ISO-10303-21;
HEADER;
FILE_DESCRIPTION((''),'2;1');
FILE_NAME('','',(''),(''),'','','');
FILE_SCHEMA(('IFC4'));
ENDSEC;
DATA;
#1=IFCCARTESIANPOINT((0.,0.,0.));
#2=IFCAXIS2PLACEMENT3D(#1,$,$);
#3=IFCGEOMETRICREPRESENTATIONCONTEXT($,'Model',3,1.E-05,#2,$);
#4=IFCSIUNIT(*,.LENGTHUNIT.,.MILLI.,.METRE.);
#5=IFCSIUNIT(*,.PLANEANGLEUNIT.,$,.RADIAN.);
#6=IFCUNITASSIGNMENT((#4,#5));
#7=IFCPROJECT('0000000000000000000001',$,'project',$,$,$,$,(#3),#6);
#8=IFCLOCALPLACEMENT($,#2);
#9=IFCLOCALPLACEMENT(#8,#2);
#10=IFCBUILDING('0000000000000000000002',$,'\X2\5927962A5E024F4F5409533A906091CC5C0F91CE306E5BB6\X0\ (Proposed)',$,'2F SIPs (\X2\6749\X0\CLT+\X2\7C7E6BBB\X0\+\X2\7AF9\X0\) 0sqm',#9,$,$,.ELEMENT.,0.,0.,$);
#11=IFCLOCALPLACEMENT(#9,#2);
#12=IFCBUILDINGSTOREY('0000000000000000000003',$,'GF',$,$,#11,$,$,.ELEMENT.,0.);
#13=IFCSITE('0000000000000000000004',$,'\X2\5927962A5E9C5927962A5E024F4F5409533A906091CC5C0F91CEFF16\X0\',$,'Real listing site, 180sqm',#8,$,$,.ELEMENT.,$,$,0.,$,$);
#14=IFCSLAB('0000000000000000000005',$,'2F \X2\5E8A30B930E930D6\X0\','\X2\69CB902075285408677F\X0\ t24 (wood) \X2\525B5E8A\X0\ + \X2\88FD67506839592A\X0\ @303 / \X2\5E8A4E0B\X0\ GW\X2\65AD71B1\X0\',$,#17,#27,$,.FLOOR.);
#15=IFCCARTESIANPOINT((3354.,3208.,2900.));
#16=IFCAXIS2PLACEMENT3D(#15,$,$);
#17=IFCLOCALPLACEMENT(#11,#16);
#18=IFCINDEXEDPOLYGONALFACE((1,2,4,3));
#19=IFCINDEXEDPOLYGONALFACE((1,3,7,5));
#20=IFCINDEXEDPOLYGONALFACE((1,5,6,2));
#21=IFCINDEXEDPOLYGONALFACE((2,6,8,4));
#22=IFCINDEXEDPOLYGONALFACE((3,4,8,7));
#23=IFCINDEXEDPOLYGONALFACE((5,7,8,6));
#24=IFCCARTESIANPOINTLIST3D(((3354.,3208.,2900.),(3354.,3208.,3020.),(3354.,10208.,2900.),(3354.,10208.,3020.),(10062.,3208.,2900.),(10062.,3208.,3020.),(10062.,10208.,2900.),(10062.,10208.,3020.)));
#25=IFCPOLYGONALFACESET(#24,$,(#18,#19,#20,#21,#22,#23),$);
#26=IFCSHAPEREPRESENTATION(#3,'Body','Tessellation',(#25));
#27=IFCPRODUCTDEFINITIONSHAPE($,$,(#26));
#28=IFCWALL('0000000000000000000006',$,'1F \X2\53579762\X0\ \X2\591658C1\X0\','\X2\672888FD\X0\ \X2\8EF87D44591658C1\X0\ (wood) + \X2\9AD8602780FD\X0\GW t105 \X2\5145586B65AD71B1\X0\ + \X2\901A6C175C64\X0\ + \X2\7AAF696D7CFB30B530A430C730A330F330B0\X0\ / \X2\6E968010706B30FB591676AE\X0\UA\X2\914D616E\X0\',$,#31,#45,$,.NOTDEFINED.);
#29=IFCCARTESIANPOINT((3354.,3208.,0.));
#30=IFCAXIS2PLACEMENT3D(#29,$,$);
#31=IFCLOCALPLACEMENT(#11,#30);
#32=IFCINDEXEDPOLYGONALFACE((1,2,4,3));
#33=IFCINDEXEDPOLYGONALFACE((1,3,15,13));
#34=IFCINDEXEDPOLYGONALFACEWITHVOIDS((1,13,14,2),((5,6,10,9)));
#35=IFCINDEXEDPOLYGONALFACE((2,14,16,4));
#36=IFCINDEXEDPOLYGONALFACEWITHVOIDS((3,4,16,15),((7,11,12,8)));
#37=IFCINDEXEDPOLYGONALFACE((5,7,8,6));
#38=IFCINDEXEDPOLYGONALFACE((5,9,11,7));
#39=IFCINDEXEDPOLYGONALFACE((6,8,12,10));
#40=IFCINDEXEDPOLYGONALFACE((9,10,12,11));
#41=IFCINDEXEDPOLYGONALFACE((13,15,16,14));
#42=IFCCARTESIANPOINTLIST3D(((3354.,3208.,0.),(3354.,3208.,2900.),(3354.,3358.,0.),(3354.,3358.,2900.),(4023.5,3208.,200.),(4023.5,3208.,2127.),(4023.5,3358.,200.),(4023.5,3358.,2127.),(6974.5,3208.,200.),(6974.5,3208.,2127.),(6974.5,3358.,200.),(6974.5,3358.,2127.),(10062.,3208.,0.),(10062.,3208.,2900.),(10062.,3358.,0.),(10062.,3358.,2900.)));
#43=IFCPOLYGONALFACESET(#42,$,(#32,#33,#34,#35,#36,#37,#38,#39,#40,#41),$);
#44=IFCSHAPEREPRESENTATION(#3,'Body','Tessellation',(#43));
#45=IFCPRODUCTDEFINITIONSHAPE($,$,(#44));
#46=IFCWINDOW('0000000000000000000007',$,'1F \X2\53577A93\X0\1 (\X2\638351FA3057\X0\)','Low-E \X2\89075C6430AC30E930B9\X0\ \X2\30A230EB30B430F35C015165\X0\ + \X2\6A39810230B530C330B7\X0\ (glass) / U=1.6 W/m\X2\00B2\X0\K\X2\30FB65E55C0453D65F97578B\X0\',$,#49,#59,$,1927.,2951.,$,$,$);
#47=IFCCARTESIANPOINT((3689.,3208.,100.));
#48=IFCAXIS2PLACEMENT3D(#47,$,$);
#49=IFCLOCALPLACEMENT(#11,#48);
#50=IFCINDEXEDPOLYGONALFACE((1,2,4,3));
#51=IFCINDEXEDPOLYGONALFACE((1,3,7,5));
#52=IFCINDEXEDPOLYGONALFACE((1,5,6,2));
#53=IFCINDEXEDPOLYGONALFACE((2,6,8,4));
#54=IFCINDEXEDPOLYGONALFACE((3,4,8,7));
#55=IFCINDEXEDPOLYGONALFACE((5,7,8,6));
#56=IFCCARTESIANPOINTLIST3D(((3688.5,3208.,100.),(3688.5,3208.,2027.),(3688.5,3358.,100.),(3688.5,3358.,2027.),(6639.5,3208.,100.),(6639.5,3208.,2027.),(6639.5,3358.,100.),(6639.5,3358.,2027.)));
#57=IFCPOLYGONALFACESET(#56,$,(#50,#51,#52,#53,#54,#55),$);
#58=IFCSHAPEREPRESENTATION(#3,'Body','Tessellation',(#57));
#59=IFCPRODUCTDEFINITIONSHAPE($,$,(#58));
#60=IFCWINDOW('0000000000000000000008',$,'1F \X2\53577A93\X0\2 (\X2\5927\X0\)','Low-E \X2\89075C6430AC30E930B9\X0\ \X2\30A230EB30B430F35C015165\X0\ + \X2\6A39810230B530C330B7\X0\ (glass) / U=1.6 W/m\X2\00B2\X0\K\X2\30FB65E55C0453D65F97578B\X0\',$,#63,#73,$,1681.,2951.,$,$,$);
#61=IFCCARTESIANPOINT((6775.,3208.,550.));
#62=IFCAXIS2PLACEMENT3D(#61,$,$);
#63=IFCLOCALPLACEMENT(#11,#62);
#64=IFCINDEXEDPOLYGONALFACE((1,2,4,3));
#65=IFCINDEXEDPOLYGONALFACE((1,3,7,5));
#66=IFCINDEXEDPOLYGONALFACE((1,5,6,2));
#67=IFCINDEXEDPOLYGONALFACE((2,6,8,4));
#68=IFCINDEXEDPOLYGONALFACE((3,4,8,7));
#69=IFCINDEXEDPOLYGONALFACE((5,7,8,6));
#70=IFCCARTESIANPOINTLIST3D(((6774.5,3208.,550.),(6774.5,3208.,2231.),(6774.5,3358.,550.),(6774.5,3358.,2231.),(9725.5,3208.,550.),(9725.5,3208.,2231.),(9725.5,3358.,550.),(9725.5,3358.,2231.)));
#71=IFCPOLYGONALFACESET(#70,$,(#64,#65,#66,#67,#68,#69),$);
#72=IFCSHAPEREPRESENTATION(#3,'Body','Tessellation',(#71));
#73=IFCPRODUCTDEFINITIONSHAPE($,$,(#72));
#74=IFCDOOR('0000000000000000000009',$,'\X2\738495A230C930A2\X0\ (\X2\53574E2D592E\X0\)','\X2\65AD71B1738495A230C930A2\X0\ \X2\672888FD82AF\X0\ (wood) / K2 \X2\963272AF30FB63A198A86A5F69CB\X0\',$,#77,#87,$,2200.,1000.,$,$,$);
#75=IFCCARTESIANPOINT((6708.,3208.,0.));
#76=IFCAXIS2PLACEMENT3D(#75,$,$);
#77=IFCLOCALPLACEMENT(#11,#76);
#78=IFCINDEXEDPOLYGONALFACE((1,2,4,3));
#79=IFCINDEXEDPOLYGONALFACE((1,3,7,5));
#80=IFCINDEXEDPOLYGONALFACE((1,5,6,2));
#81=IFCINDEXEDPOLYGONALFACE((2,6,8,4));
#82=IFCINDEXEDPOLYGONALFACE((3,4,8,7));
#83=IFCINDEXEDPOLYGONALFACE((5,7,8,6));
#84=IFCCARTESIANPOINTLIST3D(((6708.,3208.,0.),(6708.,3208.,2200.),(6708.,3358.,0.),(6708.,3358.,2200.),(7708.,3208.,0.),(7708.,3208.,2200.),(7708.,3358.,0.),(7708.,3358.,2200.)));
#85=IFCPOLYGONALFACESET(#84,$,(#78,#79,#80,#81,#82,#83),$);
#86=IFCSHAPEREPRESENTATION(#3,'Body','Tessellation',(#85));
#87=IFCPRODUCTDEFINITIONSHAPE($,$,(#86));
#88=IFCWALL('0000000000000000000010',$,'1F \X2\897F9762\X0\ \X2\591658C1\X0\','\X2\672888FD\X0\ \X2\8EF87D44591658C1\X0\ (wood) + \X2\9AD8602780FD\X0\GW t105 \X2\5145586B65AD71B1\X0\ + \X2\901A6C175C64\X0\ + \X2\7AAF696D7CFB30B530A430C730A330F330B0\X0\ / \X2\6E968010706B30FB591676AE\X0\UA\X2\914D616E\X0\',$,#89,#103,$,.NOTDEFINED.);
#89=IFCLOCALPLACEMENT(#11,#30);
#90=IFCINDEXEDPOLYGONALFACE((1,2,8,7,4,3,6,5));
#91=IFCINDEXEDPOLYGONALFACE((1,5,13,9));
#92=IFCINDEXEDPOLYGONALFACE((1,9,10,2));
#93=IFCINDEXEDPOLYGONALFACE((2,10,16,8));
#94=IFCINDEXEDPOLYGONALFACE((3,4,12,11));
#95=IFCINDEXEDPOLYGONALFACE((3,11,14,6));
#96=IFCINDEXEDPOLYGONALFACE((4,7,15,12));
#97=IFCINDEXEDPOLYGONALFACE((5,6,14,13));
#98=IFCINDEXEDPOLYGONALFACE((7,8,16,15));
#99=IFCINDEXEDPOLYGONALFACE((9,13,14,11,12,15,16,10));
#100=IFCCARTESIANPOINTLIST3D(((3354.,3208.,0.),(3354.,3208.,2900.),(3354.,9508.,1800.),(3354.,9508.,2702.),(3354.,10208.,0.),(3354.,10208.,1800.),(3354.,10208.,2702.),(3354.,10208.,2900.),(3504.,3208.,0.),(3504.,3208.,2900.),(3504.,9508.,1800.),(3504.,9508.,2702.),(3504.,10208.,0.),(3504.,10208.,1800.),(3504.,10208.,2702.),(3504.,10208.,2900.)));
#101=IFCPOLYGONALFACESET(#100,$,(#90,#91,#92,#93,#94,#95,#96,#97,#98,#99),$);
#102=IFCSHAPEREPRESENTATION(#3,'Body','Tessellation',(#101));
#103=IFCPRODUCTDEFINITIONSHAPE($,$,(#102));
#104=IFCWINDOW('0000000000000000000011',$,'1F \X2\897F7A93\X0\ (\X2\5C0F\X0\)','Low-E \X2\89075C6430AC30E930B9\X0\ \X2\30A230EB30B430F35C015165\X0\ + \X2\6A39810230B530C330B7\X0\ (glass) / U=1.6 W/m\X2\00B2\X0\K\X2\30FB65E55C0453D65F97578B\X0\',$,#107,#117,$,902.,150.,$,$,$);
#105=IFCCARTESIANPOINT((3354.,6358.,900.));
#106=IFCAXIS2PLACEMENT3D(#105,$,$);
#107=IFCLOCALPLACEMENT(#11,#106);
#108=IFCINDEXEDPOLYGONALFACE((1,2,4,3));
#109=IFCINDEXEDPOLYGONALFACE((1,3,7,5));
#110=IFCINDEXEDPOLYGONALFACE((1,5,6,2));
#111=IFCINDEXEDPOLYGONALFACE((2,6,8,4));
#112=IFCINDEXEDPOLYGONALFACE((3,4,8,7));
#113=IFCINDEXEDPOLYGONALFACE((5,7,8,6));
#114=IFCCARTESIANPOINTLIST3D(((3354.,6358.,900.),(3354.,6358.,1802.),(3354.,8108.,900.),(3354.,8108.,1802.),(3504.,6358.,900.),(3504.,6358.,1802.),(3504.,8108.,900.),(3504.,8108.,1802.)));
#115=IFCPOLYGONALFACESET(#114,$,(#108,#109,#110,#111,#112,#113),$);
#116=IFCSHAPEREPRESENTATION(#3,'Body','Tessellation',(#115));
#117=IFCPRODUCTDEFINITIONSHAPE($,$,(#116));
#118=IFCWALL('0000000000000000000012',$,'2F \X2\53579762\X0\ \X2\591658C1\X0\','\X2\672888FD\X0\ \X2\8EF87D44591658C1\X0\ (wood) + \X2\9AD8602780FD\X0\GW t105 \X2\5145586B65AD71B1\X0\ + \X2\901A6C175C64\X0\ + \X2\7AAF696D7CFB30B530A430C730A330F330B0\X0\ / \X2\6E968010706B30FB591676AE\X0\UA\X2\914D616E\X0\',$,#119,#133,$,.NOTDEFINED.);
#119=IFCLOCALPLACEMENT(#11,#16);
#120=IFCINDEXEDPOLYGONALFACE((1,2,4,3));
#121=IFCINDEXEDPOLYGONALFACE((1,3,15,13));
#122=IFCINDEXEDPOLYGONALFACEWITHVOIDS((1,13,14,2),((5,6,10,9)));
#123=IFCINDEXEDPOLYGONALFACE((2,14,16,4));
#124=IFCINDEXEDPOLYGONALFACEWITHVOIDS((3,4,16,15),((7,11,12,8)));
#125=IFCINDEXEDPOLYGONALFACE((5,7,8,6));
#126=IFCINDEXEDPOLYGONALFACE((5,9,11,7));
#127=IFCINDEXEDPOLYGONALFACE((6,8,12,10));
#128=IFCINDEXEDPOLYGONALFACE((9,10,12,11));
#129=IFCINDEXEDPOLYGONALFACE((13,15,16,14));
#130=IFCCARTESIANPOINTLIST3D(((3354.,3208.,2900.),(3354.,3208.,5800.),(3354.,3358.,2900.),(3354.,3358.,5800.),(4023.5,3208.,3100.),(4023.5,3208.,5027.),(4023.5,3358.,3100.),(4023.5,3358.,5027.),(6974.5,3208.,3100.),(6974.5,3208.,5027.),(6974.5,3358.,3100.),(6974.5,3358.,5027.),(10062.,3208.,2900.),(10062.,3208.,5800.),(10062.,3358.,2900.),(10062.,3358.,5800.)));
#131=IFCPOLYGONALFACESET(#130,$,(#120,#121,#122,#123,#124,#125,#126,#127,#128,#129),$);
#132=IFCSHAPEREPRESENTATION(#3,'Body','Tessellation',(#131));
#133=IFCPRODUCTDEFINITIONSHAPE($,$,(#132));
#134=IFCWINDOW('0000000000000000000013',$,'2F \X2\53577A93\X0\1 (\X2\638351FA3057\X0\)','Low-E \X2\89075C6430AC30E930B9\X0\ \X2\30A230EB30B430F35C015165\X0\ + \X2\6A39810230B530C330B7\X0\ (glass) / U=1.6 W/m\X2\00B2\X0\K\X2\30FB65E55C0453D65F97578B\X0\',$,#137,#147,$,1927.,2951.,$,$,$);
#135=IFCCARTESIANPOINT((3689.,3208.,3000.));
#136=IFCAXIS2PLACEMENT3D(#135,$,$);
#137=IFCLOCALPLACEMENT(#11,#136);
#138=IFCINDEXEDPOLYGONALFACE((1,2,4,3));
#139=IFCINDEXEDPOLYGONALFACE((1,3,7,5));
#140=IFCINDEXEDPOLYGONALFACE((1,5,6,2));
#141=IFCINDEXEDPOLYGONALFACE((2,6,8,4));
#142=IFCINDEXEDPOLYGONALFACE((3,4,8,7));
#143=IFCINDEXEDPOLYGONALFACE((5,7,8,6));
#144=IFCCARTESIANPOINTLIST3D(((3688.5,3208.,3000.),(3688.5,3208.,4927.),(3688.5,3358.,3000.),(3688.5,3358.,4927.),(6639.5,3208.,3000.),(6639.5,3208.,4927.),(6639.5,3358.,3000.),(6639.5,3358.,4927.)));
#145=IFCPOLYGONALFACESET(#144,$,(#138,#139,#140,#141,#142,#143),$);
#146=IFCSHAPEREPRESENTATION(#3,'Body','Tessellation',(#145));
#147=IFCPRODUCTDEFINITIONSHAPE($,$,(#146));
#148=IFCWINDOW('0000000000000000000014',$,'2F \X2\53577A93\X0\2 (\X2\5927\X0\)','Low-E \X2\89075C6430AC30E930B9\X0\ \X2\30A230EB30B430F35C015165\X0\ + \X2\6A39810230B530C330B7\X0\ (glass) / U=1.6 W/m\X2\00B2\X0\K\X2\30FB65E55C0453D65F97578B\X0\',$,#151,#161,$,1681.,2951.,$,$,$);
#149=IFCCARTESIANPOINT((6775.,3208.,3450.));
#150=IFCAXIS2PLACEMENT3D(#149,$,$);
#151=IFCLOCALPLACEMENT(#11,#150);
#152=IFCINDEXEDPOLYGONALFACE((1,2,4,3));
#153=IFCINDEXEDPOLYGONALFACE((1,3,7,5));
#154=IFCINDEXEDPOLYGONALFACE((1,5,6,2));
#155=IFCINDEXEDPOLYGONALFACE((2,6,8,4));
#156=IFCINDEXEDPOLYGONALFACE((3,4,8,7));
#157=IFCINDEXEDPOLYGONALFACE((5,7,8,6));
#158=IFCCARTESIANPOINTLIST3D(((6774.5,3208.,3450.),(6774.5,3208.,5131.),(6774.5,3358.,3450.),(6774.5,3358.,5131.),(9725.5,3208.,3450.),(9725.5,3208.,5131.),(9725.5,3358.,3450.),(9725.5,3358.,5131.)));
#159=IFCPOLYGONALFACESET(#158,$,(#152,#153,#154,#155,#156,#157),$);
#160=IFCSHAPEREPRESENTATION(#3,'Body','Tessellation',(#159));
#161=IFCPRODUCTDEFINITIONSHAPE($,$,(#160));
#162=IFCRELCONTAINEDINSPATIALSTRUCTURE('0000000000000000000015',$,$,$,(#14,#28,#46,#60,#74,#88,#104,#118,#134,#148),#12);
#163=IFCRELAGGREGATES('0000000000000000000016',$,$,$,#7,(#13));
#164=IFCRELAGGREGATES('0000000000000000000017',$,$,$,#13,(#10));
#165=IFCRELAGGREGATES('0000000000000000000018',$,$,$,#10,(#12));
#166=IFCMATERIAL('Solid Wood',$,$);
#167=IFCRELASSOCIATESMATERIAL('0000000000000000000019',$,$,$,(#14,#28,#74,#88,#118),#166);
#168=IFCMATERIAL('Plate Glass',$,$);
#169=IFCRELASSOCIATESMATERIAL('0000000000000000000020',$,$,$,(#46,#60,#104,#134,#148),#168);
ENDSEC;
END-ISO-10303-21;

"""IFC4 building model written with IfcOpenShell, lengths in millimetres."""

from ifc_helpers import new_model, si_unit, frame, frame_2d, origin, place, context, project, spatial, rectangle, extrude, material, element, fill, save


model = new_model("IFC4")

# Units and contexts
model_context = context("Model", 3, precision=1e-05, world=origin())
ifc_project = project(units=[si_unit("LENGTHUNIT", "METRE", prefix="MILLI"), si_unit("PLANEANGLEUNIT", "RADIAN")], contexts=[model_context])

# Site, building, storey
site_placement = place(None, origin())
site = spatial("IfcSite", under=ifc_project, at=site_placement, Name="大阪府大阪市住吉区遠里小野６", ObjectType="Real listing site, 180sqm", CompositionType="ELEMENT", RefElevation=0.0)
building_placement = place(site_placement, origin())
building = spatial("IfcBuilding", under=site, at=building_placement, Name="大阪市住吉区遠里小野の家 (Proposed)", ObjectType="2F SIPs (杉CLT+籾殻+竹) 0sqm", CompositionType="ELEMENT", ElevationOfRefHeight=0.0, ElevationOfTerrain=0.0)
storey_placement = place(building_placement, origin())
storey = spatial("IfcBuildingStorey", under=building, at=storey_placement, Name="GF", CompositionType="ELEMENT", Elevation=0.0)

# Slab
ifc_material_1 = material(Name="Solid Wood")
slab_1_placement = place(storey_placement, frame((3354.0, 3208.0, 2900.0)))
element("IfcSlab", 1, at=slab_1_placement, inside=storey, material=ifc_material_1, Name="2F 床スラブ", Description="構造用合板 t24 (wood) 剛床 + 製材根太 @303 / 床下 GW断熱", PredefinedType="FLOOR", context=model_context, shape_type="SweptSolid", body=[
    extrude(rectangle(XDim=6708.0, YDim=7000.0, at=frame_2d((3354.0, 3500.0))), frame((3354.0, 3208.0, 2900.0)), (0.0, 0.0, 1.0), 120.0),
])

# Wall, openings, windows, door
wall_1_placement = place(storey_placement, frame((3354.0, 3208.0, 0.0)))
wall_1 = element("IfcWall", 2, at=wall_1_placement, inside=storey, material=ifc_material_1, Name="1F 南面 外壁", Description="木製 軸組外壁 (wood) + 高性能GW t105 充填断熱 + 通気層 + 窯業系サイディング / 準耐火・外皮UA配慮", PredefinedType="NOTDEFINED", context=model_context, shape_type="SweptSolid", body=[
    extrude(rectangle(XDim=6708.0, YDim=150.0, at=frame_2d((3354.0, 75.0))), frame((3354.0, 3208.0, 0.0)), (0.0, 0.0, 1.0), 2900.0),
])
opening_1_placement = place(storey_placement, frame((3689.0, 3208.0, 100.0)))
opening_1 = element("IfcOpeningElement", 3, at=opening_1_placement, cuts=wall_1, PredefinedType="NOTDEFINED", context=model_context, shape_type="SweptSolid", body=[
    extrude(rectangle(XDim=2951.0, YDim=150.0, at=frame_2d((1475.0, 75.0))), frame((3689.0, 3208.0, 100.0)), (0.0, 0.0, 1.0), 1927.0),
])
opening_2_placement = place(storey_placement, frame((6775.0, 3208.0, 550.0)))
opening_2 = element("IfcOpeningElement", 4, at=opening_2_placement, cuts=wall_1, PredefinedType="NOTDEFINED", context=model_context, shape_type="SweptSolid", body=[
    extrude(rectangle(XDim=2951.0, YDim=150.0, at=frame_2d((1475.0, 75.0))), frame((6775.0, 3208.0, 550.0)), (0.0, 0.0, 1.0), 1681.0),
])
opening_3_placement = place(storey_placement, frame((6708.0, 3208.0, 0.0)))
opening_3 = element("IfcOpeningElement", 5, at=opening_3_placement, cuts=wall_1, PredefinedType="NOTDEFINED", context=model_context, shape_type="SweptSolid", body=[
    extrude(rectangle(XDim=1000.0, YDim=150.0, at=frame_2d((500.0, 75.0))), frame((6708.0, 3208.0, 0.0)), (0.0, 0.0, 1.0), 2200.0),
])
ifc_material_2 = material(Name="Plate Glass")
window_1_placement = place(storey_placement, frame((3689.0, 3208.0, 100.0)))
window_1 = element("IfcWindow", 6, at=window_1_placement, inside=storey, material=ifc_material_2, Name="1F 南窓1 (掃出し)", Description="Low-E 複層ガラス アルゴン封入 + 樹脂サッシ (glass) / U=1.6 W/m²K・日射取得型", OverallHeight=1927.0, OverallWidth=2951.0, context=model_context, shape_type="SweptSolid", body=[
    extrude(rectangle(XDim=2951.0, YDim=150.0, at=frame_2d((1475.0, 75.0))), frame((3689.0, 3208.0, 100.0)), (0.0, 0.0, 1.0), 1927.0),
])
fill(opening_1, window_1)
window_2_placement = place(storey_placement, frame((6775.0, 3208.0, 550.0)))
window_2 = element("IfcWindow", 7, at=window_2_placement, inside=storey, material=ifc_material_2, Name="1F 南窓2 (大)", Description="Low-E 複層ガラス アルゴン封入 + 樹脂サッシ (glass) / U=1.6 W/m²K・日射取得型", OverallHeight=1681.0, OverallWidth=2951.0, context=model_context, shape_type="SweptSolid", body=[
    extrude(rectangle(XDim=2951.0, YDim=150.0, at=frame_2d((1475.0, 75.0))), frame((6775.0, 3208.0, 550.0)), (0.0, 0.0, 1.0), 1681.0),
])
fill(opening_2, window_2)
door_placement = place(storey_placement, frame((6708.0, 3208.0, 0.0)))
door = element("IfcDoor", 8, at=door_placement, inside=storey, material=ifc_material_1, Name="玄関ドア (南中央)", Description="断熱玄関ドア 木製芯 (wood) / K2 防犯・採風機構", OverallHeight=2200.0, OverallWidth=1000.0, context=model_context, shape_type="SweptSolid", body=[
    extrude(rectangle(XDim=1000.0, YDim=150.0, at=frame_2d((500.0, 75.0))), frame((6708.0, 3208.0, 0.0)), (0.0, 0.0, 1.0), 2200.0),
])
fill(opening_3, door)

# Wall, opening, window
wall_2_placement = place(storey_placement, frame((3354.0, 3208.0, 0.0)))
wall_2 = element("IfcWall", 9, at=wall_2_placement, inside=storey, material=ifc_material_1, Name="1F 西面 外壁", Description="木製 軸組外壁 (wood) + 高性能GW t105 充填断熱 + 通気層 + 窯業系サイディング / 準耐火・外皮UA配慮", PredefinedType="NOTDEFINED", context=model_context, shape_type="SweptSolid", body=[
    extrude(rectangle(XDim=150.0, YDim=7000.0, at=frame_2d((75.0, 3500.0))), frame((3354.0, 3208.0, 0.0)), (0.0, 0.0, 1.0), 2900.0),
])
opening_4_placement = place(storey_placement, frame((3354.0, 6358.0, 900.0)))
opening_4 = element("IfcOpeningElement", 10, at=opening_4_placement, cuts=wall_2, PredefinedType="NOTDEFINED", context=model_context, shape_type="SweptSolid", body=[
    extrude(rectangle(XDim=150.0, YDim=1750.0, at=frame_2d((75.0, 875.0))), frame((3354.0, 6358.0, 900.0)), (0.0, 0.0, 1.0), 902.0),
])
window_3_placement = place(storey_placement, frame((3354.0, 6358.0, 900.0)))
window_3 = element("IfcWindow", 11, at=window_3_placement, inside=storey, material=ifc_material_2, Name="1F 西窓 (小)", Description="Low-E 複層ガラス アルゴン封入 + 樹脂サッシ (glass) / U=1.6 W/m²K・日射取得型", OverallHeight=902.0, OverallWidth=150.0, context=model_context, shape_type="SweptSolid", body=[
    extrude(rectangle(XDim=150.0, YDim=1750.0, at=frame_2d((75.0, 875.0))), frame((3354.0, 6358.0, 900.0)), (0.0, 0.0, 1.0), 902.0),
])
fill(opening_4, window_3)

# Wall, openings, windows
wall_3_placement = place(storey_placement, frame((3354.0, 3208.0, 2900.0)))
wall_3 = element("IfcWall", 12, at=wall_3_placement, inside=storey, material=ifc_material_1, Name="2F 南面 外壁", Description="木製 軸組外壁 (wood) + 高性能GW t105 充填断熱 + 通気層 + 窯業系サイディング / 準耐火・外皮UA配慮", PredefinedType="NOTDEFINED", context=model_context, shape_type="SweptSolid", body=[
    extrude(rectangle(XDim=6708.0, YDim=150.0, at=frame_2d((3354.0, 75.0))), frame((3354.0, 3208.0, 2900.0)), (0.0, 0.0, 1.0), 2900.0),
])
opening_5_placement = place(storey_placement, frame((3689.0, 3208.0, 3000.0)))
opening_5 = element("IfcOpeningElement", 13, at=opening_5_placement, cuts=wall_3, PredefinedType="NOTDEFINED", context=model_context, shape_type="SweptSolid", body=[
    extrude(rectangle(XDim=2951.0, YDim=150.0, at=frame_2d((1475.0, 75.0))), frame((3689.0, 3208.0, 3000.0)), (0.0, 0.0, 1.0), 1927.0),
])
opening_6_placement = place(storey_placement, frame((6775.0, 3208.0, 3450.0)))
opening_6 = element("IfcOpeningElement", 14, at=opening_6_placement, cuts=wall_3, PredefinedType="NOTDEFINED", context=model_context, shape_type="SweptSolid", body=[
    extrude(rectangle(XDim=2951.0, YDim=150.0, at=frame_2d((1475.0, 75.0))), frame((6775.0, 3208.0, 3450.0)), (0.0, 0.0, 1.0), 1681.0),
])
window_4_placement = place(storey_placement, frame((3689.0, 3208.0, 3000.0)))
window_4 = element("IfcWindow", 15, at=window_4_placement, inside=storey, material=ifc_material_2, Name="2F 南窓1 (掃出し)", Description="Low-E 複層ガラス アルゴン封入 + 樹脂サッシ (glass) / U=1.6 W/m²K・日射取得型", OverallHeight=1927.0, OverallWidth=2951.0, context=model_context, shape_type="SweptSolid", body=[
    extrude(rectangle(XDim=2951.0, YDim=150.0, at=frame_2d((1475.0, 75.0))), frame((3689.0, 3208.0, 3000.0)), (0.0, 0.0, 1.0), 1927.0),
])
fill(opening_5, window_4)
window_5_placement = place(storey_placement, frame((6775.0, 3208.0, 3450.0)))
window_5 = element("IfcWindow", 16, at=window_5_placement, inside=storey, material=ifc_material_2, Name="2F 南窓2 (大)", Description="Low-E 複層ガラス アルゴン封入 + 樹脂サッシ (glass) / U=1.6 W/m²K・日射取得型", OverallHeight=1681.0, OverallWidth=2951.0, context=model_context, shape_type="SweptSolid", body=[
    extrude(rectangle(XDim=2951.0, YDim=150.0, at=frame_2d((1475.0, 75.0))), frame((6775.0, 3208.0, 3450.0)), (0.0, 0.0, 1.0), 1681.0),
])
fill(opening_6, window_5)

save(model, "model.ifc")
